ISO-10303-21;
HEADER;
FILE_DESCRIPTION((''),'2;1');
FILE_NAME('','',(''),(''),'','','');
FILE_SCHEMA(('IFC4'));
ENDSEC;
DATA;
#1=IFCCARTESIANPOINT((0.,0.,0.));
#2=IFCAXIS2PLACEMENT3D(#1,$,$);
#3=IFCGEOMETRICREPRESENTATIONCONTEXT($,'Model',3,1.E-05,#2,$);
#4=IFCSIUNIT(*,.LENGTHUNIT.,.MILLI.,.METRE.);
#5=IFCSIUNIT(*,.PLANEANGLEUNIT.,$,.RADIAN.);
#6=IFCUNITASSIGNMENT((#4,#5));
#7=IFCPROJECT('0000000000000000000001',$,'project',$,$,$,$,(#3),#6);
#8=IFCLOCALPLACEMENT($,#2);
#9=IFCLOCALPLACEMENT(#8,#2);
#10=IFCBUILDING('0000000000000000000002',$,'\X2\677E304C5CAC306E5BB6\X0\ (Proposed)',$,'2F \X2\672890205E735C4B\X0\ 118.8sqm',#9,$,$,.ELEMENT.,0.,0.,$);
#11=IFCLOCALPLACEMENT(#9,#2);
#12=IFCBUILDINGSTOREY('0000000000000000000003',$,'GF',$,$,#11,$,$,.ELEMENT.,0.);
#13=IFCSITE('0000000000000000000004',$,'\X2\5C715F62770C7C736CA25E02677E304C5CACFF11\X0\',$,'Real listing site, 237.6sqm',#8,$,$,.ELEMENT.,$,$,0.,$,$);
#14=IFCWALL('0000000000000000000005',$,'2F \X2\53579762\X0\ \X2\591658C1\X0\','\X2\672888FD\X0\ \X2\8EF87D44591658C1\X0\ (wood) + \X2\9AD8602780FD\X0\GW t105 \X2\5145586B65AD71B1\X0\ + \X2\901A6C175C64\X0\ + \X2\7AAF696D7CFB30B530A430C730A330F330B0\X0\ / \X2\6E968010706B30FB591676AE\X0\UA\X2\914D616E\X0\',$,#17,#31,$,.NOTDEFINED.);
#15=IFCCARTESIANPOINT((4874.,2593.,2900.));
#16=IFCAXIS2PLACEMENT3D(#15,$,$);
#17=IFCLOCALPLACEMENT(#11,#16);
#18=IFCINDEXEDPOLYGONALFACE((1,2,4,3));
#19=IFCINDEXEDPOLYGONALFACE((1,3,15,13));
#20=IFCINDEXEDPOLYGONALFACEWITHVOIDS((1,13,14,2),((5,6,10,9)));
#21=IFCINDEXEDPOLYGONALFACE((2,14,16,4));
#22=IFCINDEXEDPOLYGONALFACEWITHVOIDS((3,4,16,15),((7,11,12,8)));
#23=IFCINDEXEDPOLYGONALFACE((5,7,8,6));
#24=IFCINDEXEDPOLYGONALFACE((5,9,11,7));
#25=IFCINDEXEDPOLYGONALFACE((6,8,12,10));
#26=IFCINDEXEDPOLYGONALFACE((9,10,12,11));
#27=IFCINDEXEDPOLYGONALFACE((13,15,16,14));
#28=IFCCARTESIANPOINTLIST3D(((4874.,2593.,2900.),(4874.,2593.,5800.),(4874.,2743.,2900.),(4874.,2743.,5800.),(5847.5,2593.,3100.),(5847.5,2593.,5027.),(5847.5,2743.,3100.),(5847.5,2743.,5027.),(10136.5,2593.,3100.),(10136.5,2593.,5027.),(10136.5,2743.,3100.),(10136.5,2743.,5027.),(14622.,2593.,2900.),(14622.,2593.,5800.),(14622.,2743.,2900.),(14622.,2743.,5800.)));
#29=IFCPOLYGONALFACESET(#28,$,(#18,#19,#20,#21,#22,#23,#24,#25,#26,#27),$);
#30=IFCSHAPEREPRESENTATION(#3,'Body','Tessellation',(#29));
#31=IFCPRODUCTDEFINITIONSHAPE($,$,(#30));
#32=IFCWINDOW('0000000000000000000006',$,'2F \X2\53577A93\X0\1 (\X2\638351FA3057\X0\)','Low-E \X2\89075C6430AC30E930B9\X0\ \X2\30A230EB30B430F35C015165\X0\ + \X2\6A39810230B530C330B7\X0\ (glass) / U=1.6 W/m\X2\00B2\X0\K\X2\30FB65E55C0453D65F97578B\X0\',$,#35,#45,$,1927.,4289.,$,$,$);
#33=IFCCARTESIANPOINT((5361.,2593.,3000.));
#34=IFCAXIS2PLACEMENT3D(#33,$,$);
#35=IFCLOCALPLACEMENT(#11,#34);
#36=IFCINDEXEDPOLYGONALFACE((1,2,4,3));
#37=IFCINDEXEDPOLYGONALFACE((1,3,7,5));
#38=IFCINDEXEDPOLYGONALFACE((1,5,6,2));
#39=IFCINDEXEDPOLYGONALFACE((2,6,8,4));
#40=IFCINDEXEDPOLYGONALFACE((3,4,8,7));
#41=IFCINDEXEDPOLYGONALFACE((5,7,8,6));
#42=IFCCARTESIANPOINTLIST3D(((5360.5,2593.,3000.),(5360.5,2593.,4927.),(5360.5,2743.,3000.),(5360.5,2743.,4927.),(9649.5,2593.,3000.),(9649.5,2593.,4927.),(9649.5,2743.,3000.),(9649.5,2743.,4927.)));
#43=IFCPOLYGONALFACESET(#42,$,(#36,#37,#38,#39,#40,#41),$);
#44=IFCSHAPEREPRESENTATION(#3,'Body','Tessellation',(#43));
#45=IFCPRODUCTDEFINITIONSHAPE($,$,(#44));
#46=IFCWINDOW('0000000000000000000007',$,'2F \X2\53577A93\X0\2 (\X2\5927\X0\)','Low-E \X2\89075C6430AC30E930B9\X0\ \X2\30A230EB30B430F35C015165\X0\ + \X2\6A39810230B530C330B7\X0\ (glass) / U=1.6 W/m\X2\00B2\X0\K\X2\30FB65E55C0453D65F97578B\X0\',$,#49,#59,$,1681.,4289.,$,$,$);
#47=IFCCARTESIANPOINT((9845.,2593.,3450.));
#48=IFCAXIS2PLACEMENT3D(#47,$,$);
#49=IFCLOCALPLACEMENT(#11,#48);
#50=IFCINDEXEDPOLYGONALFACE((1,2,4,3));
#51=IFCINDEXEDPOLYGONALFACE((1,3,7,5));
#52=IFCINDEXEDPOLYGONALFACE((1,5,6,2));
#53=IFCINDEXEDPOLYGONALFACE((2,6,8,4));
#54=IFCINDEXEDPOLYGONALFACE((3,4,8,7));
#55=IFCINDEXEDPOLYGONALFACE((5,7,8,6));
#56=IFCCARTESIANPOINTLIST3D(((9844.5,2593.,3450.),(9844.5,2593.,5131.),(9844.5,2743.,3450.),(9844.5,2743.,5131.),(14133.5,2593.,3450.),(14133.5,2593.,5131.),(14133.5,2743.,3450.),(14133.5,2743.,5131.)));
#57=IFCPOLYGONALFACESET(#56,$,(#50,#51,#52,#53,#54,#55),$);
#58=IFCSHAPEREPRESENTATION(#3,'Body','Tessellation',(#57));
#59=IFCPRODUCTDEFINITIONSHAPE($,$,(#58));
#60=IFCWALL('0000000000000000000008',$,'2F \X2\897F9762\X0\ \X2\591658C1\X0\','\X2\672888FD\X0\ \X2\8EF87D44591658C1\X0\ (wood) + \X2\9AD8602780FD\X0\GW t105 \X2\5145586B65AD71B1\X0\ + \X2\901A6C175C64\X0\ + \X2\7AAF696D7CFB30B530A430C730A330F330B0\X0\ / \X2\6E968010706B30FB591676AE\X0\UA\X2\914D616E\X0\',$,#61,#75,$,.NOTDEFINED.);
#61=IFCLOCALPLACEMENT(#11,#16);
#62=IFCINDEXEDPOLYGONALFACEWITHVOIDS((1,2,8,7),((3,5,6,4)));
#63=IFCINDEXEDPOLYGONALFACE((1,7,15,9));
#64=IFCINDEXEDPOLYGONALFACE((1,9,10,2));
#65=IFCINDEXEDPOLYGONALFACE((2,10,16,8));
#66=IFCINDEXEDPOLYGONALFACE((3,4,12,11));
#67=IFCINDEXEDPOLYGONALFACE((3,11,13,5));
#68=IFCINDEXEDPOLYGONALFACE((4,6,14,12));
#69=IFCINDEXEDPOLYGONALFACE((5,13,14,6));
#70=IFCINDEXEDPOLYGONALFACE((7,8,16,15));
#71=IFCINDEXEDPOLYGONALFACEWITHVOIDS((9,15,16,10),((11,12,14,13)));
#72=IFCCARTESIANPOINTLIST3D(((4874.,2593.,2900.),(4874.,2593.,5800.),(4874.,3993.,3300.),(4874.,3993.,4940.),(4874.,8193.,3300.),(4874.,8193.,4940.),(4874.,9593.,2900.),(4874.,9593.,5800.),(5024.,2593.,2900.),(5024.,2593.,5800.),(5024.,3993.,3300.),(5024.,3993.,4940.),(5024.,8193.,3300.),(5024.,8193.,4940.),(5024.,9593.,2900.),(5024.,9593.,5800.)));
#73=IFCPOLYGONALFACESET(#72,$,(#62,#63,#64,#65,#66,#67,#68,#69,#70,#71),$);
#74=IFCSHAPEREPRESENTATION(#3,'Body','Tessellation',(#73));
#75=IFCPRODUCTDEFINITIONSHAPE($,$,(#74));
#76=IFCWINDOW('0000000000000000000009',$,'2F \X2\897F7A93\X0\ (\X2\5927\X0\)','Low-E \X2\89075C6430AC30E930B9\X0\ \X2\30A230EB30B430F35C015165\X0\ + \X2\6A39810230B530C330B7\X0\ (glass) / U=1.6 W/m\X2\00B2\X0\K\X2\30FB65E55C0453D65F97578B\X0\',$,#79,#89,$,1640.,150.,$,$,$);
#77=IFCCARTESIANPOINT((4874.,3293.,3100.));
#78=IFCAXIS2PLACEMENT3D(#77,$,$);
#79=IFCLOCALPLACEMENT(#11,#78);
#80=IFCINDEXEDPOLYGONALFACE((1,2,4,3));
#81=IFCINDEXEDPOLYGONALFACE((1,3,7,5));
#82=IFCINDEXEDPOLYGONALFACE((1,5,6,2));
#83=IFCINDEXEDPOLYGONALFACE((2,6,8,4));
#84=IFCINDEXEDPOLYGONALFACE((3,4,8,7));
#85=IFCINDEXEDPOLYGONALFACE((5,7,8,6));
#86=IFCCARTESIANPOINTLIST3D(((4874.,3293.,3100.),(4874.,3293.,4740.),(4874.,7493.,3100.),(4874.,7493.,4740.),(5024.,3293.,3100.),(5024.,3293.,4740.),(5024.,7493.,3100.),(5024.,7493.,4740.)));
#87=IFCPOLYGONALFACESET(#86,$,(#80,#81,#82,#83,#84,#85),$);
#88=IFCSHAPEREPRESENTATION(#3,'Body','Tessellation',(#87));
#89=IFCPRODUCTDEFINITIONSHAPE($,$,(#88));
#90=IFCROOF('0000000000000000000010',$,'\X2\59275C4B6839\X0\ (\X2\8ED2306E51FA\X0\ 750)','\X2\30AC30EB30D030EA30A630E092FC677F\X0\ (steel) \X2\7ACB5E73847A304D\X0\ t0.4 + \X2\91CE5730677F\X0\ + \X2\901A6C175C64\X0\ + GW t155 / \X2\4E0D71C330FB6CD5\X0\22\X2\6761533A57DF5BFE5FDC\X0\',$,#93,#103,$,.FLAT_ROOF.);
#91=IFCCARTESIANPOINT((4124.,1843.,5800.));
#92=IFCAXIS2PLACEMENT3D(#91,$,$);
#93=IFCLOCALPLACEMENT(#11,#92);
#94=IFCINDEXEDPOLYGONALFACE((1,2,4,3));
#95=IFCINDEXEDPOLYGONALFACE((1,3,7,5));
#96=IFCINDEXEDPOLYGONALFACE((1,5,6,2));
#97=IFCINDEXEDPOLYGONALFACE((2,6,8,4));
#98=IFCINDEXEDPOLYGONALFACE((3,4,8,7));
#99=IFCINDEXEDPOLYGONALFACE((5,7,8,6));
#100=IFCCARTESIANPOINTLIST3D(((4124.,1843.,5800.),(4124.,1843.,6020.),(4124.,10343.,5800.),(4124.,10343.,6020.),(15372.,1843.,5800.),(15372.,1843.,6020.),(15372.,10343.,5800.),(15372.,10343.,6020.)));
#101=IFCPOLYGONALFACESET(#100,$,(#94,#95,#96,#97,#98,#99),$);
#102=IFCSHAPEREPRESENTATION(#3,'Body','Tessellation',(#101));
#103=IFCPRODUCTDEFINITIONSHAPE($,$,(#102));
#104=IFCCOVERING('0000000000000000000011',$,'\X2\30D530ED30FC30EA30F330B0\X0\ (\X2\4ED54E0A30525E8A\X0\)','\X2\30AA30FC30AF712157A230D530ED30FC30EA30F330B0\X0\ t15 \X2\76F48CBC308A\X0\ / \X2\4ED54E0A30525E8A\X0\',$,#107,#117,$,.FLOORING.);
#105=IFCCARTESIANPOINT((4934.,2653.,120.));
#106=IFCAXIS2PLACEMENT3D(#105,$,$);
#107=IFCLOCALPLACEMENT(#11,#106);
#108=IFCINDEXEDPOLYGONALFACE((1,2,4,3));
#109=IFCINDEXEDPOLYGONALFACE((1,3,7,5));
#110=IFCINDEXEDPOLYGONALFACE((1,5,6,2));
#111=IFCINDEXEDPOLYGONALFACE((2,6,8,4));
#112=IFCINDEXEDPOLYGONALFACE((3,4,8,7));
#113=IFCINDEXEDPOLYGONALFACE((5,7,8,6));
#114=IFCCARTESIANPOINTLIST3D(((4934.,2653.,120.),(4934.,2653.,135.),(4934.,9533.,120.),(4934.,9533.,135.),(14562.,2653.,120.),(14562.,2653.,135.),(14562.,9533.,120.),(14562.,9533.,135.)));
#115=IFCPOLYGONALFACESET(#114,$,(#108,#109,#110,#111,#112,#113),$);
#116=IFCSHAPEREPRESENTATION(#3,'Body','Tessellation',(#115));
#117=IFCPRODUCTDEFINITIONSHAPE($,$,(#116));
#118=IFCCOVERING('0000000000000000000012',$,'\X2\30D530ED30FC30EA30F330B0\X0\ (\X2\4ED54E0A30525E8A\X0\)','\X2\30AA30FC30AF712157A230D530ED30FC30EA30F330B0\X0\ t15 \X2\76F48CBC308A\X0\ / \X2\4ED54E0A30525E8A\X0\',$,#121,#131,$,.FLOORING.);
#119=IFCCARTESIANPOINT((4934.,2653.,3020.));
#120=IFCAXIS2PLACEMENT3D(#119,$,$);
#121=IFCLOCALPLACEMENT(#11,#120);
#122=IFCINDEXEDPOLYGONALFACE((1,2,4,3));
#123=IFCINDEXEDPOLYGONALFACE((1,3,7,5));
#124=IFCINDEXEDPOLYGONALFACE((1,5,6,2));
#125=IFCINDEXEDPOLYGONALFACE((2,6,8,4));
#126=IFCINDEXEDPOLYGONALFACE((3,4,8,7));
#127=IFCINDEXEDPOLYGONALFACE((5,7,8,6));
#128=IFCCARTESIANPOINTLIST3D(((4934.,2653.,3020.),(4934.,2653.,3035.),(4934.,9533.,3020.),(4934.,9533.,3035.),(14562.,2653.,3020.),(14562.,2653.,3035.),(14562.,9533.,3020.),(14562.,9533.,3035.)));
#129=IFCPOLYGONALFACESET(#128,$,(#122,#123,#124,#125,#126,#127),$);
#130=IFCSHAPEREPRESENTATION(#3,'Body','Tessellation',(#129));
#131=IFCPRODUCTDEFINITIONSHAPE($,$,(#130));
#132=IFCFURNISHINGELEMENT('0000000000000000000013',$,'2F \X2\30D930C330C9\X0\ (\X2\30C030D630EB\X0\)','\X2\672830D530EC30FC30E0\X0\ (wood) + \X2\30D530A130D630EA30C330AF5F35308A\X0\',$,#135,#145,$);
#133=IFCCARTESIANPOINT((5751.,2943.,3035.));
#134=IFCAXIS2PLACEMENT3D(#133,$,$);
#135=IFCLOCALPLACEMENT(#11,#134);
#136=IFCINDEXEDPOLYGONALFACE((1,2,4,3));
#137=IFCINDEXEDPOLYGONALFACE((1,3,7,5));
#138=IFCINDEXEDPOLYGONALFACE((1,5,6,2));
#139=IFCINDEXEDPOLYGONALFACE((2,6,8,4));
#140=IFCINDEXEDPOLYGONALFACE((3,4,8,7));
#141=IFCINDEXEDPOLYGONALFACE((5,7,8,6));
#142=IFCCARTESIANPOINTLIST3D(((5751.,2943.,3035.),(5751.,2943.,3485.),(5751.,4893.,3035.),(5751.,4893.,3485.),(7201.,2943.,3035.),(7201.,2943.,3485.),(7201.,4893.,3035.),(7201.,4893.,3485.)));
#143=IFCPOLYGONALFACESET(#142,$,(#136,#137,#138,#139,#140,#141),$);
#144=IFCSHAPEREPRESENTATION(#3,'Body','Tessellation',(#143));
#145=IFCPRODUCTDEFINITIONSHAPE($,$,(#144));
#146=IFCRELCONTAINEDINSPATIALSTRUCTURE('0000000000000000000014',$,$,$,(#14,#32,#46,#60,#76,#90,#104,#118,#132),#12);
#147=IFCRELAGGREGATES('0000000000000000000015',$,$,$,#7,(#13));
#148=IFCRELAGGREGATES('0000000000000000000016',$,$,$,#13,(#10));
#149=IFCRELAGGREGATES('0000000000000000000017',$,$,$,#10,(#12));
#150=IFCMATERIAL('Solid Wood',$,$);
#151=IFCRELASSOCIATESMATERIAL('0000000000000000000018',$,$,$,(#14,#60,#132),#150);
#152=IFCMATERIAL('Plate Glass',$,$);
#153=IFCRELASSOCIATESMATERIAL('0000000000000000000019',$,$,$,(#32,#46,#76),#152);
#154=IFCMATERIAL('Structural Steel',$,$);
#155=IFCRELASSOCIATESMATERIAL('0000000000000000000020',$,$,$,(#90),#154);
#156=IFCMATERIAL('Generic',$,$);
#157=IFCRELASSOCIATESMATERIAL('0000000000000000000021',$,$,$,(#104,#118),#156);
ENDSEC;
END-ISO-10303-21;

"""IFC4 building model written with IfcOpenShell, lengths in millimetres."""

from ifc_helpers import new_model, si_unit, frame, frame_2d, origin, place, context, project, spatial, rectangle, extrude, material, element, fill, save


model = new_model("IFC4")

# Units and contexts
model_context = context("Model", 3, precision=1e-05, world=origin())
ifc_project = project(units=[si_unit("LENGTHUNIT", "METRE", prefix="MILLI"), si_unit("PLANEANGLEUNIT", "RADIAN")], contexts=[model_context])

# Site, building, storey
site_placement = place(None, origin())
site = spatial("IfcSite", under=ifc_project, at=site_placement, Name="山形県米沢市松が岬１", ObjectType="Real listing site, 237.6sqm", CompositionType="ELEMENT", RefElevation=0.0)
building_placement = place(site_placement, origin())
building = spatial("IfcBuilding", under=site, at=building_placement, Name="松が岬の家 (Proposed)", ObjectType="2F 木造平屋 118.8sqm", CompositionType="ELEMENT", ElevationOfRefHeight=0.0, ElevationOfTerrain=0.0)
storey_placement = place(building_placement, origin())
storey = spatial("IfcBuildingStorey", under=building, at=storey_placement, Name="GF", CompositionType="ELEMENT", Elevation=0.0)

# Shared definitions
ifc_material_1 = material(Name="Solid Wood")

# Shared definitions
ifc_material_2 = material(Name="Plate Glass")

# Wall, openings, windows
wall_1_placement = place(storey_placement, frame((4874.0, 2593.0, 2900.0)))
wall_1 = element("IfcWall", 1, at=wall_1_placement, inside=storey, material=ifc_material_1, Name="2F 南面 外壁", Description="木製 軸組外壁 (wood) + 高性能GW t105 充填断熱 + 通気層 + 窯業系サイディング / 準耐火・外皮UA配慮", PredefinedType="NOTDEFINED", context=model_context, shape_type="SweptSolid", body=[
    extrude(rectangle(XDim=9748.0, YDim=150.0, at=frame_2d((4874.0, 75.0))), frame((4874.0, 2593.0, 2900.0)), (0.0, 0.0, 1.0), 2900.0),
])
opening_1_placement = place(storey_placement, frame((5361.0, 2593.0, 3000.0)))
opening_1 = element("IfcOpeningElement", 2, at=opening_1_placement, cuts=wall_1, PredefinedType="NOTDEFINED", context=model_context, shape_type="SweptSolid", body=[
    extrude(rectangle(XDim=4289.0, YDim=150.0, at=frame_2d((2144.0, 75.0))), frame((5361.0, 2593.0, 3000.0)), (0.0, 0.0, 1.0), 1927.0),
])
opening_2_placement = place(storey_placement, frame((9845.0, 2593.0, 3450.0)))
opening_2 = element("IfcOpeningElement", 3, at=opening_2_placement, cuts=wall_1, PredefinedType="NOTDEFINED", context=model_context, shape_type="SweptSolid", body=[
    extrude(rectangle(XDim=4289.0, YDim=150.0, at=frame_2d((2144.0, 75.0))), frame((9845.0, 2593.0, 3450.0)), (0.0, 0.0, 1.0), 1681.0),
])
window_1_placement = place(storey_placement, frame((5361.0, 2593.0, 3000.0)))
window_1 = element("IfcWindow", 4, at=window_1_placement, inside=storey, material=ifc_material_2, Name="2F 南窓1 (掃出し)", Description="Low-E 複層ガラス アルゴン封入 + 樹脂サッシ (glass) / U=1.6 W/m²K・日射取得型", OverallHeight=1927.0, OverallWidth=4289.0, context=model_context, shape_type="SweptSolid", body=[
    extrude(rectangle(XDim=4289.0, YDim=150.0, at=frame_2d((2144.0, 75.0))), frame((5361.0, 2593.0, 3000.0)), (0.0, 0.0, 1.0), 1927.0),
])
fill(opening_1, window_1)
window_2_placement = place(storey_placement, frame((9845.0, 2593.0, 3450.0)))
window_2 = element("IfcWindow", 5, at=window_2_placement, inside=storey, material=ifc_material_2, Name="2F 南窓2 (大)", Description="Low-E 複層ガラス アルゴン封入 + 樹脂サッシ (glass) / U=1.6 W/m²K・日射取得型", OverallHeight=1681.0, OverallWidth=4289.0, context=model_context, shape_type="SweptSolid", body=[
    extrude(rectangle(XDim=4289.0, YDim=150.0, at=frame_2d((2144.0, 75.0))), frame((9845.0, 2593.0, 3450.0)), (0.0, 0.0, 1.0), 1681.0),
])
fill(opening_2, window_2)

# Wall, opening, window
wall_2_placement = place(storey_placement, frame((4874.0, 2593.0, 2900.0)))
wall_2 = element("IfcWall", 6, at=wall_2_placement, inside=storey, material=ifc_material_1, Name="2F 西面 外壁", Description="木製 軸組外壁 (wood) + 高性能GW t105 充填断熱 + 通気層 + 窯業系サイディング / 準耐火・外皮UA配慮", PredefinedType="NOTDEFINED", context=model_context, shape_type="SweptSolid", body=[
    extrude(rectangle(XDim=150.0, YDim=7000.0, at=frame_2d((75.0, 3500.0))), frame((4874.0, 2593.0, 2900.0)), (0.0, 0.0, 1.0), 2900.0),
])
opening_3_placement = place(storey_placement, frame((4874.0, 3293.0, 3100.0)))
opening_3 = element("IfcOpeningElement", 7, at=opening_3_placement, cuts=wall_2, PredefinedType="NOTDEFINED", context=model_context, shape_type="SweptSolid", body=[
    extrude(rectangle(XDim=150.0, YDim=4200.0, at=frame_2d((75.0, 2100.0))), frame((4874.0, 3293.0, 3100.0)), (0.0, 0.0, 1.0), 1640.0),
])
window_3_placement = place(storey_placement, frame((4874.0, 3293.0, 3100.0)))
window_3 = element("IfcWindow", 8, at=window_3_placement, inside=storey, material=ifc_material_2, Name="2F 西窓 (大)", Description="Low-E 複層ガラス アルゴン封入 + 樹脂サッシ (glass) / U=1.6 W/m²K・日射取得型", OverallHeight=1640.0, OverallWidth=150.0, context=model_context, shape_type="SweptSolid", body=[
    extrude(rectangle(XDim=150.0, YDim=4200.0, at=frame_2d((75.0, 2100.0))), frame((4874.0, 3293.0, 3100.0)), (0.0, 0.0, 1.0), 1640.0),
])
fill(opening_3, window_3)

# Roof
ifc_material_3 = material(Name="Structural Steel")
roof_placement = place(storey_placement, frame((4124.0, 1843.0, 5800.0)))
element("IfcRoof", 9, at=roof_placement, inside=storey, material=ifc_material_3, Name="大屋根 (軒の出 750)", Description="ガルバリウム鋼板 (steel) 立平葺き t0.4 + 野地板 + 通気層 + GW t155 / 不燃・法22条区域対応", PredefinedType="FLAT_ROOF", context=model_context, shape_type="SweptSolid", body=[
    extrude(rectangle(XDim=11248.0, YDim=8500.0, at=frame_2d((5624.0, 4250.0))), frame((4124.0, 1843.0, 5800.0)), (0.0, 0.0, 1.0), 220.0),
])

# Coverings
ifc_material_4 = material(Name="Generic")
covering_1_placement = place(storey_placement, frame((4934.0, 2653.0, 120.0)))
element("IfcCovering", 10, at=covering_1_placement, inside=storey, material=ifc_material_4, Name="フローリング (仕上げ床)", Description="オーク無垢フローリング t15 直貼り / 仕上げ床", PredefinedType="FLOORING", context=model_context, shape_type="SweptSolid", body=[
    extrude(rectangle(XDim=9628.0, YDim=6880.0, at=frame_2d((4814.0, 3440.0))), frame((4934.0, 2653.0, 120.0)), (0.0, 0.0, 1.0), 15.0),
])
covering_2_placement = place(storey_placement, frame((4934.0, 2653.0, 3020.0)))
element("IfcCovering", 11, at=covering_2_placement, inside=storey, material=ifc_material_4, Name="フローリング (仕上げ床)", Description="オーク無垢フローリング t15 直貼り / 仕上げ床", PredefinedType="FLOORING", context=model_context, shape_type="SweptSolid", body=[
    extrude(rectangle(XDim=9628.0, YDim=6880.0, at=frame_2d((4814.0, 3440.0))), frame((4934.0, 2653.0, 3020.0)), (0.0, 0.0, 1.0), 15.0),
])

# Furnishing element
furnishing_placement = place(storey_placement, frame((5751.0, 2943.0, 3035.0)))
element("IfcFurnishingElement", 12, at=furnishing_placement, inside=storey, material=ifc_material_1, Name="2F ベッド (ダブル)", Description="木フレーム (wood) + ファブリック張り", context=model_context, shape_type="SweptSolid", body=[
    extrude(rectangle(XDim=1450.0, YDim=1950.0, at=frame_2d((725.0, 975.0))), frame((5751.0, 2943.0, 3035.0)), (0.0, 0.0, 1.0), 450.0),
])

save(model, "model.ifc")
